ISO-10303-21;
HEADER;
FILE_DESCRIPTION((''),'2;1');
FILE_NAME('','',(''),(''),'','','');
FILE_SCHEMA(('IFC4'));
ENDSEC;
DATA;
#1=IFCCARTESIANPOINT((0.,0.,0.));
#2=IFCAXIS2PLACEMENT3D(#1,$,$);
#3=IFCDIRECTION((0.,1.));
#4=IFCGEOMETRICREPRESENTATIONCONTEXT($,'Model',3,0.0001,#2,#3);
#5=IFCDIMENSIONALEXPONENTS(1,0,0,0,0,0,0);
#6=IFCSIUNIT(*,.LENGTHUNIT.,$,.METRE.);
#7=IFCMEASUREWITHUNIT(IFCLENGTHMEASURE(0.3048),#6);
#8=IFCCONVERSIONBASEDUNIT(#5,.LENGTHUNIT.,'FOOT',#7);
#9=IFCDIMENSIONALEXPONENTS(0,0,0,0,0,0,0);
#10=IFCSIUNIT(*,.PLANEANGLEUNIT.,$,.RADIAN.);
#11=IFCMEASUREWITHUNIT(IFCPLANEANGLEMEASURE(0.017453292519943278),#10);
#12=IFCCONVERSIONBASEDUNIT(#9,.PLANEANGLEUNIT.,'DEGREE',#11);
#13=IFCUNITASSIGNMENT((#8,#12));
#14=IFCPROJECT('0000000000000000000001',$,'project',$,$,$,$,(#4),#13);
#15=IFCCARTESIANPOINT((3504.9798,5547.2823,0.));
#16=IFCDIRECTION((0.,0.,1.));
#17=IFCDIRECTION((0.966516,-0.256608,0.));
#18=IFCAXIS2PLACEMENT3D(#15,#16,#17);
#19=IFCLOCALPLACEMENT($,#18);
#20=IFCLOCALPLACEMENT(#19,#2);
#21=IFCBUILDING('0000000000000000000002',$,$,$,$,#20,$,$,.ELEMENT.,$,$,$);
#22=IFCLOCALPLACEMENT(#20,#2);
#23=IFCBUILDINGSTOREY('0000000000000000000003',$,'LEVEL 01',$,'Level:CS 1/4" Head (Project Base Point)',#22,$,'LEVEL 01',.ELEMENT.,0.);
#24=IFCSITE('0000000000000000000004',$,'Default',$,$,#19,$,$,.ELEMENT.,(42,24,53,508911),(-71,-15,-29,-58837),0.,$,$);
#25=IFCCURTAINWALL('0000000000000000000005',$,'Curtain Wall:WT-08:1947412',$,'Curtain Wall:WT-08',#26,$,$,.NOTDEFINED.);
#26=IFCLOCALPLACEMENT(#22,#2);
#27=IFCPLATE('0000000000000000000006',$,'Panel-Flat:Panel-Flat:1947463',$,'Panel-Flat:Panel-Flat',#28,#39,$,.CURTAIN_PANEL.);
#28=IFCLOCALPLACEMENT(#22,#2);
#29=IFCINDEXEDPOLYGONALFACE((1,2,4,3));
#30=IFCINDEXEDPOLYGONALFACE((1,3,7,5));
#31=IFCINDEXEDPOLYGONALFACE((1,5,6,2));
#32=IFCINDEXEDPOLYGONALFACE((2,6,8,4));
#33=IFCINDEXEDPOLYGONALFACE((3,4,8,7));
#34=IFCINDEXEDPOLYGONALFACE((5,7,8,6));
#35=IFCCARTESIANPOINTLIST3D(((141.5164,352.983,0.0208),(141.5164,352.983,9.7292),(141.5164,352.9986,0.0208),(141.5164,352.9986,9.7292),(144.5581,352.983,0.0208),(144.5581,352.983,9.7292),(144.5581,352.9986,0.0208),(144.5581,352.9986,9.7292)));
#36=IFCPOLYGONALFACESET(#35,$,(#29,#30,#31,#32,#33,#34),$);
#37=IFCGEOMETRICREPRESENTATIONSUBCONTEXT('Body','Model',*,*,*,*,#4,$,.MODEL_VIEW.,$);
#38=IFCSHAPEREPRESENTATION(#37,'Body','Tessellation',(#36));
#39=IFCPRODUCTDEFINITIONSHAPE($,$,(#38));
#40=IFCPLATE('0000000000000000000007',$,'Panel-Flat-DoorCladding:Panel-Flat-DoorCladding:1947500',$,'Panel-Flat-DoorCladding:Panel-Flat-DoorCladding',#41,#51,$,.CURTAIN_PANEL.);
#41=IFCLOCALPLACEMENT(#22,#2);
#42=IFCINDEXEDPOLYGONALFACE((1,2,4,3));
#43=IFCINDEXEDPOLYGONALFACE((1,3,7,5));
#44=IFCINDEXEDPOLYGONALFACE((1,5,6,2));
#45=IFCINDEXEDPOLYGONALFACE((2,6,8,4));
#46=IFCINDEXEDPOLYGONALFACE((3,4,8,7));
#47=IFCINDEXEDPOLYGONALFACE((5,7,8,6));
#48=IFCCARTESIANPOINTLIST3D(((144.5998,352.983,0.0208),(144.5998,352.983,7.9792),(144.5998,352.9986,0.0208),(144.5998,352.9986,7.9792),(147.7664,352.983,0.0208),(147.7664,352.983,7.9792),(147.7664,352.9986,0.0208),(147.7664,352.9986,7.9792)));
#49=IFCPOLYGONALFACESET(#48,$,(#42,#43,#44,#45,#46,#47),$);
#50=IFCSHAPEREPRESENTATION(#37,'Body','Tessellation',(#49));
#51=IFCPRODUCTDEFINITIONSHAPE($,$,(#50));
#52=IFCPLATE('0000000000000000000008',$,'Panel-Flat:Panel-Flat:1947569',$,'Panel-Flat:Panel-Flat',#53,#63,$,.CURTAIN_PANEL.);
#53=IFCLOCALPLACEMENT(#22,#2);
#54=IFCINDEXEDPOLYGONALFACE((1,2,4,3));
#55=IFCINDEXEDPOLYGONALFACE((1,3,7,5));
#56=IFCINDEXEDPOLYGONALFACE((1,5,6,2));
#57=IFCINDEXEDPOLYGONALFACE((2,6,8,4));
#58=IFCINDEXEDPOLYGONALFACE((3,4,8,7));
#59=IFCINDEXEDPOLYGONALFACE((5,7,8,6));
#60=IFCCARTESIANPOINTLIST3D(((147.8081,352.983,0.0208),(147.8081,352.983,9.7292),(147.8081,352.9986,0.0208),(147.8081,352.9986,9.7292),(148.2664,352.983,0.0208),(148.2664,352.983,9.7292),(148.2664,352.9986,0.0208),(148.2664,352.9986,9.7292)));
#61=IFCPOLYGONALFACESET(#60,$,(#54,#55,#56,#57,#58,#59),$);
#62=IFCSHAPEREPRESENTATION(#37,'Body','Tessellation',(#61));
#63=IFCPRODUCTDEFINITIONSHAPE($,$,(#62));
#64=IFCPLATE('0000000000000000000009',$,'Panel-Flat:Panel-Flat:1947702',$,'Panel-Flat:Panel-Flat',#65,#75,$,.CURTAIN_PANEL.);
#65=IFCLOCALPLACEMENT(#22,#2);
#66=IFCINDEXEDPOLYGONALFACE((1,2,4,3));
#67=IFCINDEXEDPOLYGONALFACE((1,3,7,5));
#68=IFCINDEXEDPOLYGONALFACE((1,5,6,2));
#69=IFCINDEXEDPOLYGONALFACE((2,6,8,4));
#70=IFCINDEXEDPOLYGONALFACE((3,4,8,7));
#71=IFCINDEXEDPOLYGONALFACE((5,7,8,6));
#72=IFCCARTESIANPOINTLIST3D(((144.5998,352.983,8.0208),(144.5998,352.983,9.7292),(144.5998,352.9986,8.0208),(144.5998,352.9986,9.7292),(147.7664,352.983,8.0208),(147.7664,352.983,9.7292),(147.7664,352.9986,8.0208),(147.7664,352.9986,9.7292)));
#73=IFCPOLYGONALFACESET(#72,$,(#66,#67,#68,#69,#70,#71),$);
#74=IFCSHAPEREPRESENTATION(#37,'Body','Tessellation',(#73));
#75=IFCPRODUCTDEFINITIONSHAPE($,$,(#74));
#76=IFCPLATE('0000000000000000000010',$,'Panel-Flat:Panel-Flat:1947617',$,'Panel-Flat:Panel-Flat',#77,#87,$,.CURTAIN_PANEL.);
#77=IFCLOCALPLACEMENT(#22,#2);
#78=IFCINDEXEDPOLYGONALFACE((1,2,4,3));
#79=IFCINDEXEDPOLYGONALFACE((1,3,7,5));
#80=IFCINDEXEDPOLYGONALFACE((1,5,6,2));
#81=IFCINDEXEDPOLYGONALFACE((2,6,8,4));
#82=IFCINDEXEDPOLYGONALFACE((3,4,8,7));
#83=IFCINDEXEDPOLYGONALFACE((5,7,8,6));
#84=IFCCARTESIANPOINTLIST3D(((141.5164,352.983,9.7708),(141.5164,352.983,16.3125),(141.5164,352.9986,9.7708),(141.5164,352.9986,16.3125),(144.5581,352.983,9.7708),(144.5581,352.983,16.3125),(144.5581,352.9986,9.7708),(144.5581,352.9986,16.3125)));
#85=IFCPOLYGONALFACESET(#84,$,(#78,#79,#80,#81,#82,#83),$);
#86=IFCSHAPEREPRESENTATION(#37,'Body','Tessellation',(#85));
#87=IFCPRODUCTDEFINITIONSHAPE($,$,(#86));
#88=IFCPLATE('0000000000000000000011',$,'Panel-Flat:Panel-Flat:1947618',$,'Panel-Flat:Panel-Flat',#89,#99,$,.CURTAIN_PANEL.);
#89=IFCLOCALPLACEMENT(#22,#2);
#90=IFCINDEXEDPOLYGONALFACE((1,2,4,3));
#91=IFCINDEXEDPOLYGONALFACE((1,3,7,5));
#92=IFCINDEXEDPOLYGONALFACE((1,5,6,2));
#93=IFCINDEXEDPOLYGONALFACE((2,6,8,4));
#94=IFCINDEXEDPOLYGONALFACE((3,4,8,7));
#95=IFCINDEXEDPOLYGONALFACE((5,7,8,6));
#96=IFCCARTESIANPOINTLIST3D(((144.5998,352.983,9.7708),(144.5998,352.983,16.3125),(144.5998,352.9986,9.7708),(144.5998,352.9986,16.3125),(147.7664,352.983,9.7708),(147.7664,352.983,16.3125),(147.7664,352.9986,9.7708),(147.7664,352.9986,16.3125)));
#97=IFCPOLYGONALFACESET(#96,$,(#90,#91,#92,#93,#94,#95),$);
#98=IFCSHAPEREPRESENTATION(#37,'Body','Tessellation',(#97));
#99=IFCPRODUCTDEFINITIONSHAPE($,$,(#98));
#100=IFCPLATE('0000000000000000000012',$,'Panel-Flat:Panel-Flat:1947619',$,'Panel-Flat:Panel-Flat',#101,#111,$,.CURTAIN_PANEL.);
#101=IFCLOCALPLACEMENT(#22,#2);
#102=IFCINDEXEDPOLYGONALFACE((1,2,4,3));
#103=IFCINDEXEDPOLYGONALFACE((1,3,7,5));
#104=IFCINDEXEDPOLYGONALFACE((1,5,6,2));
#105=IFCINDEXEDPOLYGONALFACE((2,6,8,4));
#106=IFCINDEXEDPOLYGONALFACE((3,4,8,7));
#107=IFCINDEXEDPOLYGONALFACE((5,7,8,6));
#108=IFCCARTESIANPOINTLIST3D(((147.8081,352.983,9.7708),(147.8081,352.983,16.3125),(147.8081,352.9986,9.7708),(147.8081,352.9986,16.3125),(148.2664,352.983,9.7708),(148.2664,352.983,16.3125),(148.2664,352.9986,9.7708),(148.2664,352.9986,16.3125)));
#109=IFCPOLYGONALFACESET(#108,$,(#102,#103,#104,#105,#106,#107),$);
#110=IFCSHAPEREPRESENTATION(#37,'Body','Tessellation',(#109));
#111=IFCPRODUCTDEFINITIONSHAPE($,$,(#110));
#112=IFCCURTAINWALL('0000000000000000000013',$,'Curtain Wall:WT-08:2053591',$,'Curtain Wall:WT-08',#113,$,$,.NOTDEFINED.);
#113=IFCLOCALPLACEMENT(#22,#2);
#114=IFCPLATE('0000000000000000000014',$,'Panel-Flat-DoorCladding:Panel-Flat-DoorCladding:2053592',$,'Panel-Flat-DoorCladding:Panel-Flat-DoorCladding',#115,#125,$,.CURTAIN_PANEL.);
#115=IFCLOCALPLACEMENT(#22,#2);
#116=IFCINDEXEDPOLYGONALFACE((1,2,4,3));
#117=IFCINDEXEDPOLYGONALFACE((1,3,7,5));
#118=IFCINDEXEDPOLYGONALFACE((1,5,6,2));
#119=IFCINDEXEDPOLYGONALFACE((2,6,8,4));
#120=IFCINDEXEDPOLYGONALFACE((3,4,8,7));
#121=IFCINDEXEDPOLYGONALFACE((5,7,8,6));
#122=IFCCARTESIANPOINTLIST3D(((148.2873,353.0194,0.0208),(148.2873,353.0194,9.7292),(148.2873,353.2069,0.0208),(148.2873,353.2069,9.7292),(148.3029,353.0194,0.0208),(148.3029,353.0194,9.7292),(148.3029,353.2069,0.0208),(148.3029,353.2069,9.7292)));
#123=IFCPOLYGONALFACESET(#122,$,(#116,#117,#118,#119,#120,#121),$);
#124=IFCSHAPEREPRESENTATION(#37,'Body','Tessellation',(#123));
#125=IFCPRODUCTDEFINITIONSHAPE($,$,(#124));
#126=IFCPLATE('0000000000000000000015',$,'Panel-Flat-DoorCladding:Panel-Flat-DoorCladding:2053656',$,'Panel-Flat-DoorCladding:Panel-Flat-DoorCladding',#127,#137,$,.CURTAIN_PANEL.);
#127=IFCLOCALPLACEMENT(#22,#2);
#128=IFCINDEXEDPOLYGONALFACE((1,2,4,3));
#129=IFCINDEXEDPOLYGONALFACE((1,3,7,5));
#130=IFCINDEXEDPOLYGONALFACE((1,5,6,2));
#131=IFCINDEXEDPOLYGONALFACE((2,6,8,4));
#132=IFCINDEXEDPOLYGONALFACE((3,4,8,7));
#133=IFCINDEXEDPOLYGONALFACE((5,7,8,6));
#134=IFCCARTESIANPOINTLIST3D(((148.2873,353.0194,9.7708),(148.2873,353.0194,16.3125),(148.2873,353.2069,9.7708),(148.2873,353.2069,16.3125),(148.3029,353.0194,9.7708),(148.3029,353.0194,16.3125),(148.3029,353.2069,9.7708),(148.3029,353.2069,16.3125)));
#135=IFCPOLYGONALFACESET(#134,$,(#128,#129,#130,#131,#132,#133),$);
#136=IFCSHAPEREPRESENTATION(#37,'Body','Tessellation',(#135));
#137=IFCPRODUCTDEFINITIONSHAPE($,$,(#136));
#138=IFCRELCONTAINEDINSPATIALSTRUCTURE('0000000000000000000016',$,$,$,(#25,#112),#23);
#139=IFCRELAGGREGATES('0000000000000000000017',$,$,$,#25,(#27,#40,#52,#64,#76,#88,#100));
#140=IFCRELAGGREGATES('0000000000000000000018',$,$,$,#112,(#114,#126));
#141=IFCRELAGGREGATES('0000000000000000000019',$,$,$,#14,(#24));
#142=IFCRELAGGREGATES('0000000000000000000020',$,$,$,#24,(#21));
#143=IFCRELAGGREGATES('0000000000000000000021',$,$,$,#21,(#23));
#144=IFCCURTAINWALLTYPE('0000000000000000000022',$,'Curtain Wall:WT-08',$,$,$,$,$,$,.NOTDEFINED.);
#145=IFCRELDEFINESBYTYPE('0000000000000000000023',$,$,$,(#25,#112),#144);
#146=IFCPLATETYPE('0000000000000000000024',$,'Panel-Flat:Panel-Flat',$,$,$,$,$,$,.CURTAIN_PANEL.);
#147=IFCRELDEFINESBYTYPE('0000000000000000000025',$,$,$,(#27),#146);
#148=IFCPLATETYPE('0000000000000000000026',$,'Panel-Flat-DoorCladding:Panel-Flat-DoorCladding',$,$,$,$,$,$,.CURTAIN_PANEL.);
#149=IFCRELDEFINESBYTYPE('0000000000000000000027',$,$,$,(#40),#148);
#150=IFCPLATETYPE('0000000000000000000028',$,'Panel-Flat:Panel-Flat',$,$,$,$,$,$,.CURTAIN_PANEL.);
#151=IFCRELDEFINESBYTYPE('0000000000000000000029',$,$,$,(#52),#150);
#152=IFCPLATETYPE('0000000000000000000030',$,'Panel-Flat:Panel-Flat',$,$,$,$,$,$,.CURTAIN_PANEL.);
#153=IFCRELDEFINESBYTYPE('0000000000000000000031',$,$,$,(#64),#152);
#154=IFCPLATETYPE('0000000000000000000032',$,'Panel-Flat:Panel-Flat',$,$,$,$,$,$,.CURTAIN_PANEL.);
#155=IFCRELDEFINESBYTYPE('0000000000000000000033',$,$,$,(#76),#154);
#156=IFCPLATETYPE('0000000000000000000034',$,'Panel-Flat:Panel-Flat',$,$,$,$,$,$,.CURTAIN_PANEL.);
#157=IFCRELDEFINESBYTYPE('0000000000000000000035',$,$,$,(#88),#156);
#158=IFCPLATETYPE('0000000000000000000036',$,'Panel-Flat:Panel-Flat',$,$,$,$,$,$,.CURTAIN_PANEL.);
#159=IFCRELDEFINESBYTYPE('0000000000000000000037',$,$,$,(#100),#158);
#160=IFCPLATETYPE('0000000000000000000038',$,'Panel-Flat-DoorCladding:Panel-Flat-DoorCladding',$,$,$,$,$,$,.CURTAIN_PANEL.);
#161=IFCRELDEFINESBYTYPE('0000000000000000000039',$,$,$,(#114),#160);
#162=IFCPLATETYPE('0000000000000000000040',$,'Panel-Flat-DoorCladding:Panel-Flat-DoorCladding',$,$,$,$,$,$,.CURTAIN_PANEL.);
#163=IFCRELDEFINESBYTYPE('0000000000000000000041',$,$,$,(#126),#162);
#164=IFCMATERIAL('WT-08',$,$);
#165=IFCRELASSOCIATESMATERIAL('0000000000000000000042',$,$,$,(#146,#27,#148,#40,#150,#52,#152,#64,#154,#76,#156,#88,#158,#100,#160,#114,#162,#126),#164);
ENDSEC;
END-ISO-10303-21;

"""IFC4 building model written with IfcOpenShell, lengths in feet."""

from ifc_helpers import new_model, entity, si_unit, converted_unit, direction, frame, origin, place, context, subcontext, project, spatial, indexed_curve, outline, extrude, source, transform, mapped, material, type_object, type_shapes, element, aggregate, save


model = new_model("IFC4")

# Units and contexts
model_context = context("Model", 3, precision=0.0001, world=origin(), true_north=direction((0.0, 1.0)))
body_context = subcontext(model_context, "Body", "Model", "MODEL_VIEW")
ifc_project = project(units=[converted_unit("LENGTHUNIT", "FOOT", entity("IfcLengthMeasure", 0.3048), si_unit("LENGTHUNIT", "METRE"), dimensions=[1, 0, 0, 0, 0, 0, 0]), converted_unit("PLANEANGLEUNIT", "DEGREE", entity("IfcPlaneAngleMeasure", 0.017453292519943278), si_unit("PLANEANGLEUNIT", "RADIAN"), dimensions=[0, 0, 0, 0, 0, 0, 0])], contexts=[model_context])

# Site, building, storey
site_placement = place(None, frame((3504.9798, 5547.2823, 0.0), z_axis=(0.0, 0.0, 1.0), x_axis=(0.966516, -0.256608, 0.0)))
site = spatial("IfcSite", under=ifc_project, at=site_placement, Name="Default", CompositionType="ELEMENT", RefLatitude=(42, 24, 53, 508911), RefLongitude=(-71, -15, -29, -58837), RefElevation=0.0)
building_placement = place(site_placement, origin())
building = spatial("IfcBuilding", under=site, at=building_placement, CompositionType="ELEMENT")
storey_placement = place(building_placement, origin())
storey = spatial("IfcBuildingStorey", under=building, at=storey_placement, Name="LEVEL 01", ObjectType="Level:CS 1/4\" Head (Project Base Point)", LongName="LEVEL 01", CompositionType="ELEMENT", Elevation=0.0)

# Curtain wall, plates
curtain_wall_type_1 = type_object("IfcCurtainWallType", Name="Curtain Wall:WT-08", PredefinedType="NOTDEFINED")
curtain_wall_1_placement = place(storey_placement, origin())
curtain_wall_1 = element("IfcCurtainWall", 1, at=curtain_wall_1_placement, inside=storey, type_object=curtain_wall_type_1, Name="Curtain Wall:WT-08:1947412", ObjectType="Curtain Wall:WT-08", PredefinedType="NOTDEFINED")
ifc_material_1 = material(Name="WT-08")
plate_type_1 = type_object("IfcPlateType", Name="Panel-Flat:Panel-Flat", PredefinedType="CURTAIN_PANEL", material=ifc_material_1)
shared_shape_1 = source(origin(), body_context, "Body", "SweptSolid", [
    extrude(outline(indexed_curve([(-0.0078, -1.5208), (0.0078, -1.5208), (0.0078, 1.5208), (-0.0078, 1.5208), (-0.0078, -1.5208)], self_intersect=False)), frame((1.5208, 0.0078, 0.0), z_axis=(0.0, 0.0, 1.0), x_axis=(0.0, -1.0, 0.0)), (0.0, 0.0, 1.0), 9.7083),
])
type_shapes(plate_type_1, [shared_shape_1])
plate_1_placement = place(curtain_wall_1_placement, frame((141.5164, 352.983, 0.0208)))
plate_1 = element("IfcPlate", 2, at=plate_1_placement, type_object=plate_type_1, material=ifc_material_1, Name="Panel-Flat:Panel-Flat:1947463", ObjectType="Panel-Flat:Panel-Flat", PredefinedType="CURTAIN_PANEL", context=body_context, shape_type="MappedRepresentation", body=[
    mapped(shared_shape_1, transform((0.0, 0.0, 0.0), scale=1.0)),
])
plate_type_2 = type_object("IfcPlateType", Name="Panel-Flat-DoorCladding:Panel-Flat-DoorCladding", PredefinedType="CURTAIN_PANEL", material=ifc_material_1)
shared_shape_2 = source(origin(), body_context, "Body", "SweptSolid", [
    extrude(outline(indexed_curve([(-0.0078, -1.5833), (0.0078, -1.5833), (0.0078, 1.5833), (-0.0078, 1.5833), (-0.0078, -1.5833)], self_intersect=False)), frame((1.5833, 0.0078, 0.0), z_axis=(0.0, 0.0, 1.0), x_axis=(0.0, -1.0, 0.0)), (0.0, 0.0, 1.0), 7.9583),
])
type_shapes(plate_type_2, [shared_shape_2])
plate_2_placement = place(curtain_wall_1_placement, frame((144.5998, 352.983, 0.0208)))
plate_2 = element("IfcPlate", 3, at=plate_2_placement, type_object=plate_type_2, material=ifc_material_1, Name="Panel-Flat-DoorCladding:Panel-Flat-DoorCladding:1947500", ObjectType="Panel-Flat-DoorCladding:Panel-Flat-DoorCladding", PredefinedType="CURTAIN_PANEL", context=body_context, shape_type="MappedRepresentation", body=[
    mapped(shared_shape_2, transform((0.0, 0.0, 0.0), scale=1.0)),
])
plate_type_3 = type_object("IfcPlateType", Name="Panel-Flat:Panel-Flat", PredefinedType="CURTAIN_PANEL", material=ifc_material_1)
shared_shape_3 = source(origin(), body_context, "Body", "SweptSolid", [
    extrude(outline(indexed_curve([(-0.0078, -0.2292), (0.0078, -0.2292), (0.0078, 0.2292), (-0.0078, 0.2292), (-0.0078, -0.2292)], self_intersect=False)), frame((0.2292, 0.0078, 0.0), z_axis=(0.0, 0.0, 1.0), x_axis=(0.0, -1.0, 0.0)), (0.0, 0.0, 1.0), 9.7083),
])
type_shapes(plate_type_3, [shared_shape_3])
plate_3_placement = place(curtain_wall_1_placement, frame((147.8081, 352.983, 0.0208)))
plate_3 = element("IfcPlate", 4, at=plate_3_placement, type_object=plate_type_3, material=ifc_material_1, Name="Panel-Flat:Panel-Flat:1947569", ObjectType="Panel-Flat:Panel-Flat", PredefinedType="CURTAIN_PANEL", context=body_context, shape_type="MappedRepresentation", body=[
    mapped(shared_shape_3, transform((0.0, 0.0, 0.0), scale=1.0)),
])
plate_type_4 = type_object("IfcPlateType", Name="Panel-Flat:Panel-Flat", PredefinedType="CURTAIN_PANEL", material=ifc_material_1)
shared_shape_4 = source(origin(), body_context, "Body", "SweptSolid", [
    extrude(outline(indexed_curve([(-0.0078, -1.5833), (0.0078, -1.5833), (0.0078, 1.5833), (-0.0078, 1.5833), (-0.0078, -1.5833)], self_intersect=False)), frame((1.5833, 0.0078, 0.0), z_axis=(0.0, 0.0, 1.0), x_axis=(0.0, -1.0, 0.0)), (0.0, 0.0, 1.0), 1.7083),
])
type_shapes(plate_type_4, [shared_shape_4])
plate_4_placement = place(curtain_wall_1_placement, frame((144.5998, 352.983, 8.0208)))
plate_4 = element("IfcPlate", 5, at=plate_4_placement, type_object=plate_type_4, material=ifc_material_1, Name="Panel-Flat:Panel-Flat:1947702", ObjectType="Panel-Flat:Panel-Flat", PredefinedType="CURTAIN_PANEL", context=body_context, shape_type="MappedRepresentation", body=[
    mapped(shared_shape_4, transform((0.0, 0.0, 0.0), scale=1.0)),
])
plate_type_5 = type_object("IfcPlateType", Name="Panel-Flat:Panel-Flat", PredefinedType="CURTAIN_PANEL", material=ifc_material_1)
shared_shape_5 = source(origin(), body_context, "Body", "SweptSolid", [
    extrude(outline(indexed_curve([(-0.0078, -1.5208), (0.0078, -1.5208), (0.0078, 1.5208), (-0.0078, 1.5208), (-0.0078, -1.5208)], self_intersect=False)), frame((1.5208, 0.0078, 0.0), z_axis=(0.0, 0.0, 1.0), x_axis=(0.0, -1.0, 0.0)), (0.0, 0.0, 1.0), 6.5417),
])
type_shapes(plate_type_5, [shared_shape_5])
plate_5_placement = place(curtain_wall_1_placement, frame((141.5164, 352.983, 9.7708)))
plate_5 = element("IfcPlate", 6, at=plate_5_placement, type_object=plate_type_5, material=ifc_material_1, Name="Panel-Flat:Panel-Flat:1947617", ObjectType="Panel-Flat:Panel-Flat", PredefinedType="CURTAIN_PANEL", context=body_context, shape_type="MappedRepresentation", body=[
    mapped(shared_shape_5, transform((0.0, 0.0, 0.0), scale=1.0)),
])
plate_type_6 = type_object("IfcPlateType", Name="Panel-Flat:Panel-Flat", PredefinedType="CURTAIN_PANEL", material=ifc_material_1)
shared_shape_6 = source(origin(), body_context, "Body", "SweptSolid", [
    extrude(outline(indexed_curve([(-0.0078, -1.5833), (0.0078, -1.5833), (0.0078, 1.5833), (-0.0078, 1.5833), (-0.0078, -1.5833)], self_intersect=False)), frame((1.5833, 0.0078, 0.0), z_axis=(0.0, 0.0, 1.0), x_axis=(0.0, -1.0, 0.0)), (0.0, 0.0, 1.0), 6.5417),
])
type_shapes(plate_type_6, [shared_shape_6])
plate_6_placement = place(curtain_wall_1_placement, frame((144.5998, 352.983, 9.7708)))
plate_6 = element("IfcPlate", 7, at=plate_6_placement, type_object=plate_type_6, material=ifc_material_1, Name="Panel-Flat:Panel-Flat:1947618", ObjectType="Panel-Flat:Panel-Flat", PredefinedType="CURTAIN_PANEL", context=body_context, shape_type="MappedRepresentation", body=[
    mapped(shared_shape_6, transform((0.0, 0.0, 0.0), scale=1.0)),
])
plate_type_7 = type_object("IfcPlateType", Name="Panel-Flat:Panel-Flat", PredefinedType="CURTAIN_PANEL", material=ifc_material_1)
shared_shape_7 = source(origin(), body_context, "Body", "SweptSolid", [
    extrude(outline(indexed_curve([(-0.0078, -0.2292), (0.0078, -0.2292), (0.0078, 0.2292), (-0.0078, 0.2292), (-0.0078, -0.2292)], self_intersect=False)), frame((0.2292, 0.0078, 0.0), z_axis=(0.0, 0.0, 1.0), x_axis=(0.0, -1.0, 0.0)), (0.0, 0.0, 1.0), 6.5417),
])
type_shapes(plate_type_7, [shared_shape_7])
plate_7_placement = place(curtain_wall_1_placement, frame((147.8081, 352.983, 9.7708)))
plate_7 = element("IfcPlate", 8, at=plate_7_placement, type_object=plate_type_7, material=ifc_material_1, Name="Panel-Flat:Panel-Flat:1947619", ObjectType="Panel-Flat:Panel-Flat", PredefinedType="CURTAIN_PANEL", context=body_context, shape_type="MappedRepresentation", body=[
    mapped(shared_shape_7, transform((0.0, 0.0, 0.0), scale=1.0)),
])
aggregate(curtain_wall_1, [plate_1, plate_2, plate_3, plate_4, plate_5, plate_6, plate_7])

# Curtain wall, plates
curtain_wall_2_placement = place(storey_placement, origin())
curtain_wall_2 = element("IfcCurtainWall", 9, at=curtain_wall_2_placement, inside=storey, type_object=curtain_wall_type_1, Name="Curtain Wall:WT-08:2053591", ObjectType="Curtain Wall:WT-08", PredefinedType="NOTDEFINED")
plate_type_8 = type_object("IfcPlateType", Name="Panel-Flat-DoorCladding:Panel-Flat-DoorCladding", PredefinedType="CURTAIN_PANEL", material=ifc_material_1)
shared_shape_8 = source(origin(), body_context, "Body", "SweptSolid", [
    extrude(outline(indexed_curve([(-0.0078, -0.0937), (0.0078, -0.0937), (0.0078, 0.0937), (-0.0078, 0.0937), (-0.0078, -0.0937)], self_intersect=False)), frame((0.0937, 0.0078, 0.0), z_axis=(0.0, 0.0, 1.0), x_axis=(0.0, -1.0, 0.0)), (0.0, 0.0, 1.0), 9.7083),
])
type_shapes(plate_type_8, [shared_shape_8])
plate_8_placement = place(curtain_wall_2_placement, frame((148.3029, 353.0194, 0.0208), z_axis=(0.0, 0.0, 1.0), x_axis=(0.0, 1.0, 0.0)))
plate_8 = element("IfcPlate", 10, at=plate_8_placement, type_object=plate_type_8, material=ifc_material_1, Name="Panel-Flat-DoorCladding:Panel-Flat-DoorCladding:2053592", ObjectType="Panel-Flat-DoorCladding:Panel-Flat-DoorCladding", PredefinedType="CURTAIN_PANEL", context=body_context, shape_type="MappedRepresentation", body=[
    mapped(shared_shape_8, transform((0.0, 0.0, 0.0), scale=1.0)),
])
plate_type_9 = type_object("IfcPlateType", Name="Panel-Flat-DoorCladding:Panel-Flat-DoorCladding", PredefinedType="CURTAIN_PANEL", material=ifc_material_1)
shared_shape_9 = source(origin(), body_context, "Body", "SweptSolid", [
    extrude(outline(indexed_curve([(-0.0078, -0.0937), (0.0078, -0.0937), (0.0078, 0.0937), (-0.0078, 0.0937), (-0.0078, -0.0937)], self_intersect=False)), frame((0.0937, 0.0078, 0.0), z_axis=(0.0, 0.0, 1.0), x_axis=(0.0, -1.0, 0.0)), (0.0, 0.0, 1.0), 6.5417),
])
type_shapes(plate_type_9, [shared_shape_9])
plate_9_placement = place(curtain_wall_2_placement, frame((148.3029, 353.0194, 9.7708), z_axis=(0.0, 0.0, 1.0), x_axis=(0.0, 1.0, 0.0)))
plate_9 = element("IfcPlate", 11, at=plate_9_placement, type_object=plate_type_9, material=ifc_material_1, Name="Panel-Flat-DoorCladding:Panel-Flat-DoorCladding:2053656", ObjectType="Panel-Flat-DoorCladding:Panel-Flat-DoorCladding", PredefinedType="CURTAIN_PANEL", context=body_context, shape_type="MappedRepresentation", body=[
    mapped(shared_shape_9, transform((0.0, 0.0, 0.0), scale=1.0)),
])
aggregate(curtain_wall_2, [plate_8, plate_9])

save(model, "model.ifc")
